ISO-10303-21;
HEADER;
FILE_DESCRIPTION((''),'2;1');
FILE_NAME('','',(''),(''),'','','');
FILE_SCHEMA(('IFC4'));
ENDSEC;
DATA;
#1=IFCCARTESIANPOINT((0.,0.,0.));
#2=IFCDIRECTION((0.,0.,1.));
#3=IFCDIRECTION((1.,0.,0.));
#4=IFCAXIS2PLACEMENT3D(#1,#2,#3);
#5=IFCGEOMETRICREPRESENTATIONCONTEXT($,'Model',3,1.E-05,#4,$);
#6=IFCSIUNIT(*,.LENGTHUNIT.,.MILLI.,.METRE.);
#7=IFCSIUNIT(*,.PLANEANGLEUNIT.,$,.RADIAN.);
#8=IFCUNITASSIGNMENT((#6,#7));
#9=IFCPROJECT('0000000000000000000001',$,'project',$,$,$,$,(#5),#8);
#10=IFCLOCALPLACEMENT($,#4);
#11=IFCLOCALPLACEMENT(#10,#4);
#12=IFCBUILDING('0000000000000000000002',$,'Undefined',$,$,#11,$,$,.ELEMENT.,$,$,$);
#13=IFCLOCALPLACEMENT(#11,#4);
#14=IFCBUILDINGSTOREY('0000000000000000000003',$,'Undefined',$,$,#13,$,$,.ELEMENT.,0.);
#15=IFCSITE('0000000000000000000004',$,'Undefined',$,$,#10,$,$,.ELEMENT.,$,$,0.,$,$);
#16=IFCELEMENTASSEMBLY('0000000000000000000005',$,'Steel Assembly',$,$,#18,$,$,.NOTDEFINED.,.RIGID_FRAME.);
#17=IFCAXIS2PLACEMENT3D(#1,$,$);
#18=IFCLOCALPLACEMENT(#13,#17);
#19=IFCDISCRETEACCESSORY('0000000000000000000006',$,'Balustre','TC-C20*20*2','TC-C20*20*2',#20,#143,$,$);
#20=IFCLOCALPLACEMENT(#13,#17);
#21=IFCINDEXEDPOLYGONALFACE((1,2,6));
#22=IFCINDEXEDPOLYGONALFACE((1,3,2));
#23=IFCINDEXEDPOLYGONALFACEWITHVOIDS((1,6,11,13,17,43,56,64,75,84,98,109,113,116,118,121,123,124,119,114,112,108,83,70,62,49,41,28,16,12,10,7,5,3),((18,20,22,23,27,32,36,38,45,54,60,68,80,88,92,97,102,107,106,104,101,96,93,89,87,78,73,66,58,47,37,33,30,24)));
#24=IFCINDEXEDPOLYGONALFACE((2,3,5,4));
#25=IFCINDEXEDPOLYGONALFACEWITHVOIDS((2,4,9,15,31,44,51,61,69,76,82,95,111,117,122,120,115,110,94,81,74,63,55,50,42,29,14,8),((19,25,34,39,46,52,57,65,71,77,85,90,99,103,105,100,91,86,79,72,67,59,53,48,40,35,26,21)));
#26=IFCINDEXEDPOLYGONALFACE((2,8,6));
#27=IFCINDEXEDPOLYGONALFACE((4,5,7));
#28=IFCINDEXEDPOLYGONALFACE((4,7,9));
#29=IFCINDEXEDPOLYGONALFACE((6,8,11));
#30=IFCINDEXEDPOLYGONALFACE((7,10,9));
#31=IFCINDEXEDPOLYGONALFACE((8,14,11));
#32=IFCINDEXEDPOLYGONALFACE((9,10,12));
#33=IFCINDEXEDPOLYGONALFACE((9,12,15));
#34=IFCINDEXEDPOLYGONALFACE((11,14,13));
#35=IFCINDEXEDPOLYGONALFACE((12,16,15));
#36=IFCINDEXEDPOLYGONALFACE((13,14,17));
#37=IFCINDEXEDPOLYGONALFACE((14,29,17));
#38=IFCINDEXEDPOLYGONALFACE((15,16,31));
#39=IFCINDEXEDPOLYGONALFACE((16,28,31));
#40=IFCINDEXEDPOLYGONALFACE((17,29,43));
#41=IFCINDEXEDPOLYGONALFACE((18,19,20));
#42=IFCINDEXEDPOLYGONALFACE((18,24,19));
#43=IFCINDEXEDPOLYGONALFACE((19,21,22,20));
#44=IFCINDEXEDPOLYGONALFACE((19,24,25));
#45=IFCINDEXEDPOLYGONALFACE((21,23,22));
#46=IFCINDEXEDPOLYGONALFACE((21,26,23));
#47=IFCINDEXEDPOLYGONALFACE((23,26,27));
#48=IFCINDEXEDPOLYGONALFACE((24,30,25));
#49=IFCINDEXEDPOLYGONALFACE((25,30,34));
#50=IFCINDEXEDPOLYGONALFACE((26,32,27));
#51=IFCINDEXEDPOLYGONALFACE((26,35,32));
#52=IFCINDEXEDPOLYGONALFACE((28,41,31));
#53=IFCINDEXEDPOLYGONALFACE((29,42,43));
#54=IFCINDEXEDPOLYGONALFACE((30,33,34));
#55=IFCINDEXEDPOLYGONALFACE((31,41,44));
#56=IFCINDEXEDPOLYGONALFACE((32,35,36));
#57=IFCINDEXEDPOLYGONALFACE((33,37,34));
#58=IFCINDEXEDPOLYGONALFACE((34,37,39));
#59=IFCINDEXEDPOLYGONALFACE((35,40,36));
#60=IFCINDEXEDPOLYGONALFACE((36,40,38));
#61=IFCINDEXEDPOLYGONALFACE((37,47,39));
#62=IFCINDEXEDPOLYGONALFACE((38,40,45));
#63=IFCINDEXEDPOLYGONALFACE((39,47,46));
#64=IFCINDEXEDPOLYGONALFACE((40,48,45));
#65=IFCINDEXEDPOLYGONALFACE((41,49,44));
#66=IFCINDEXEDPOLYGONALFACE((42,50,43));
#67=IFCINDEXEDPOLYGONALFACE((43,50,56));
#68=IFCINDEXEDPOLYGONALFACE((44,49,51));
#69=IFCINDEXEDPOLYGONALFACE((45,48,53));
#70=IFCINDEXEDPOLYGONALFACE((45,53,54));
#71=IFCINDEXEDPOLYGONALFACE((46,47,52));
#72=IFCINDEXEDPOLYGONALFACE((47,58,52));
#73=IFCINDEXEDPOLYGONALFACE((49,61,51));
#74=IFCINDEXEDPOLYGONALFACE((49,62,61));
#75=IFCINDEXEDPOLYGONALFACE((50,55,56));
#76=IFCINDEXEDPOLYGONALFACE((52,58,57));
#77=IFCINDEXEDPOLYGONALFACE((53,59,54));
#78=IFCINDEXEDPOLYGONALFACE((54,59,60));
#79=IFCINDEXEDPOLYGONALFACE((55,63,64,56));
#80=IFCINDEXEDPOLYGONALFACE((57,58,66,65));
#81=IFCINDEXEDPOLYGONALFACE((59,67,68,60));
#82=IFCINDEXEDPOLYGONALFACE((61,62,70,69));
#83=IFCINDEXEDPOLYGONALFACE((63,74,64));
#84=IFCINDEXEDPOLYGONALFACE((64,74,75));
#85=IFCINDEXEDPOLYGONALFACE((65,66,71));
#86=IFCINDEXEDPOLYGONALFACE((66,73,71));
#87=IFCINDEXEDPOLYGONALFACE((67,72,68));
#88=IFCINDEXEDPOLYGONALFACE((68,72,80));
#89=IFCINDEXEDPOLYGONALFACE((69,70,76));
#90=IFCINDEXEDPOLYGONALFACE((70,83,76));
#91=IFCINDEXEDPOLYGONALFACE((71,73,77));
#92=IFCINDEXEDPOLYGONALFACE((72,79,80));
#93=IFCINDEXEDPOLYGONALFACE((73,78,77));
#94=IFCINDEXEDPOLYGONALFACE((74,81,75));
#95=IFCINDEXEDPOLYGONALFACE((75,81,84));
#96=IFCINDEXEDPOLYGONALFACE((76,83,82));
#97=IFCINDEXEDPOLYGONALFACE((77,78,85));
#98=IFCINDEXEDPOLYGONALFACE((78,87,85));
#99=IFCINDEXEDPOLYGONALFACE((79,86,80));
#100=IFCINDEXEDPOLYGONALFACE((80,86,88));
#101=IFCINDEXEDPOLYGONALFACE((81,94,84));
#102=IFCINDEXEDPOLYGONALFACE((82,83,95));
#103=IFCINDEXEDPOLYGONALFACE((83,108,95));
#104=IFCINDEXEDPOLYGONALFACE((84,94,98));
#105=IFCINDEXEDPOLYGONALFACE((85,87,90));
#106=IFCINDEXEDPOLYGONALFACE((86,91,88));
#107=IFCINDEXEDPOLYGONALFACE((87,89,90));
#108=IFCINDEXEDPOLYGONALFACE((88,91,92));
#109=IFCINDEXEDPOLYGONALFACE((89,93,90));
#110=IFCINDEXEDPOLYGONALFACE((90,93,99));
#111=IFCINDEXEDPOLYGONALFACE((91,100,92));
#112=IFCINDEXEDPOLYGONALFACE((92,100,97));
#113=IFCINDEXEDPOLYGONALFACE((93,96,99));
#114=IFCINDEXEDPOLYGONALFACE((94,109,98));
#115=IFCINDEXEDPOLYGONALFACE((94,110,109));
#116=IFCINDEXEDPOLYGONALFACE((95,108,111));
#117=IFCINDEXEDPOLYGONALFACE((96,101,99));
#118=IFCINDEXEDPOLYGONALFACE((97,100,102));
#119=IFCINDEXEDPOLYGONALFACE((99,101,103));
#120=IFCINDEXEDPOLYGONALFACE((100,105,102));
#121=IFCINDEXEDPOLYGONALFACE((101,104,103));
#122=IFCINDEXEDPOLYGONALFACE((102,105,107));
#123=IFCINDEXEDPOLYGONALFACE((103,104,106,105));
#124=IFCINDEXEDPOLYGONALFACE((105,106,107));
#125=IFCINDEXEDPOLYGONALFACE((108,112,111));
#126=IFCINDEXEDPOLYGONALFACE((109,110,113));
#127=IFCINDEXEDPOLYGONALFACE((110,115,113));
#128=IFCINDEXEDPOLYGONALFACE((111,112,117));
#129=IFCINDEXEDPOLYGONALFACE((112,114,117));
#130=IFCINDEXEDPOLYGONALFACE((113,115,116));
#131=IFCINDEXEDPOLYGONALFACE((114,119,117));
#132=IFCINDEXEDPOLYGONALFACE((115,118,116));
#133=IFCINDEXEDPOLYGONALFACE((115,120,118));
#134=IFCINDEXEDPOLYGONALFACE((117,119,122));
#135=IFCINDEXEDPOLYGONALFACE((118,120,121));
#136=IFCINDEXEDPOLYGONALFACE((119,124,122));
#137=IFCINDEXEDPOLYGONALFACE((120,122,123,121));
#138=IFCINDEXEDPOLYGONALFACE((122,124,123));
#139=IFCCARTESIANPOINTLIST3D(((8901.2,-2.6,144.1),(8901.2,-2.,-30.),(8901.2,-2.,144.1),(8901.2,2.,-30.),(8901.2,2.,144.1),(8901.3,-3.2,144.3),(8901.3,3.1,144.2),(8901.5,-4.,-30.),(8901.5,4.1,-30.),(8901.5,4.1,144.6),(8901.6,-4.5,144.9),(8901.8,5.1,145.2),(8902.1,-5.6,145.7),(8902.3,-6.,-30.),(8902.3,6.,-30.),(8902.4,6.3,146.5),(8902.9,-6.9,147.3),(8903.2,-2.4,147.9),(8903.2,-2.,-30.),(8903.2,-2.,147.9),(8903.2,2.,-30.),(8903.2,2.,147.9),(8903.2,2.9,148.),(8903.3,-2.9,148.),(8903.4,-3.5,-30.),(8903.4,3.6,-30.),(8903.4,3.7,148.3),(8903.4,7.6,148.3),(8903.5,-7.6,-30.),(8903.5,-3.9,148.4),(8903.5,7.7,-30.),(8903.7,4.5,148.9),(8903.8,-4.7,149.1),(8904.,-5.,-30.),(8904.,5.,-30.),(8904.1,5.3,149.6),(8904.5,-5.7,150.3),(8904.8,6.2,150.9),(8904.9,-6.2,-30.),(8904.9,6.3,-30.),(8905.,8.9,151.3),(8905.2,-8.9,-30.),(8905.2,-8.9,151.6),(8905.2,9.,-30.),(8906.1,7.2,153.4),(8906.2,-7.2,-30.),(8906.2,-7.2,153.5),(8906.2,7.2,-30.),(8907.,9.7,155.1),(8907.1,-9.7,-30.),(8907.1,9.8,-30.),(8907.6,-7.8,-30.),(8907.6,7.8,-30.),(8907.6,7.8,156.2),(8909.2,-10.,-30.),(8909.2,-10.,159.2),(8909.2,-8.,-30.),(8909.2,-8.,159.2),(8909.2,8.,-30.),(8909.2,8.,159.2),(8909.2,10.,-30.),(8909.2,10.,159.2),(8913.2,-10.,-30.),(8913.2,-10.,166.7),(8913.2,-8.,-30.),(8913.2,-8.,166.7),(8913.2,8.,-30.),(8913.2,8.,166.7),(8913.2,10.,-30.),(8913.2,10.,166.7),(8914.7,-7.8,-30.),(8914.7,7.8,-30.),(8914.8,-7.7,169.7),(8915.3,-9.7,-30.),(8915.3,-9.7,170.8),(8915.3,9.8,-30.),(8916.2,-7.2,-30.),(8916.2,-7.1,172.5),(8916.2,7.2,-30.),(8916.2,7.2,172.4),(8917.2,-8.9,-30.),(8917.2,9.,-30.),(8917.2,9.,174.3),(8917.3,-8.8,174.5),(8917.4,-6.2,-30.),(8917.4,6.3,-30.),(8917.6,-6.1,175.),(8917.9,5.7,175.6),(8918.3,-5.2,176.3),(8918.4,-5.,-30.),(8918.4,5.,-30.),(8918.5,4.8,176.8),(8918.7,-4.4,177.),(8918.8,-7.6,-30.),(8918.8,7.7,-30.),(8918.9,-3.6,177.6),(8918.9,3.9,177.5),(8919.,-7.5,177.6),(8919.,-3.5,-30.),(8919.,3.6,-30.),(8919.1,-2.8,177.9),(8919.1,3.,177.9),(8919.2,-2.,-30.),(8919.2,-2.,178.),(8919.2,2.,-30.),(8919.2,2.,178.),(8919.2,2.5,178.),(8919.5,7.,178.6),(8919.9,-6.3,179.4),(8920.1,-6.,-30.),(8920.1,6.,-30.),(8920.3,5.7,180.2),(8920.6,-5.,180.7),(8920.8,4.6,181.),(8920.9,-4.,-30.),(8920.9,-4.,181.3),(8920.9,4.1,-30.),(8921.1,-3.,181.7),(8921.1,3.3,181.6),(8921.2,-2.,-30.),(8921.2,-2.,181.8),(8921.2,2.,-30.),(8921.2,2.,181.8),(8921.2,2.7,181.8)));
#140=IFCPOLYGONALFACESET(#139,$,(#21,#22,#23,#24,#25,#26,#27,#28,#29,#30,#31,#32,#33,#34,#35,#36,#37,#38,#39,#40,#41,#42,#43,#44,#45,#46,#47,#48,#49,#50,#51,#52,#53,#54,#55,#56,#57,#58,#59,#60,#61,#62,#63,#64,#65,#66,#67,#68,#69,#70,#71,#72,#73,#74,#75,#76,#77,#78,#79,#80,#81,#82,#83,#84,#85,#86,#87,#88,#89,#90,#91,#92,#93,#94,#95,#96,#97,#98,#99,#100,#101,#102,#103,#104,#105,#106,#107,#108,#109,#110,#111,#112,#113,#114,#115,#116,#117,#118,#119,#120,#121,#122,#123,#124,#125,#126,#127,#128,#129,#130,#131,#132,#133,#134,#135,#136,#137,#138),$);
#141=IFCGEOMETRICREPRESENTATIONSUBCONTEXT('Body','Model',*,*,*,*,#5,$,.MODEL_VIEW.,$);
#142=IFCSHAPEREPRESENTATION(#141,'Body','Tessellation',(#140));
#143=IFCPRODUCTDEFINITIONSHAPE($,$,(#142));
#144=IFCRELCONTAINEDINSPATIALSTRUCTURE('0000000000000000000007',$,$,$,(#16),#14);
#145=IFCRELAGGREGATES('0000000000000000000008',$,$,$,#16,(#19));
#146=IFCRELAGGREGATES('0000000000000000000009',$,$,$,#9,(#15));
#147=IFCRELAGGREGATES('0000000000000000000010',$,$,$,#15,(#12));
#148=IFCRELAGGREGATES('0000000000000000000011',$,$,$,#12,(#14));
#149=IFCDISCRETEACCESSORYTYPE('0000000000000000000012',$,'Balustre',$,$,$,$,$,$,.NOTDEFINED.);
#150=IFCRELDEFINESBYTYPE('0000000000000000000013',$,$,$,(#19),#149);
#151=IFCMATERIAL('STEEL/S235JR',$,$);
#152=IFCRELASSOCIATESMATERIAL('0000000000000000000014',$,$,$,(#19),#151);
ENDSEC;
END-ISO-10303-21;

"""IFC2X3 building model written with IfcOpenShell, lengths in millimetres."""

from ifc_helpers import new_model, si_unit, frame, origin_with_axes, origin_2d_with_axis, place, context, subcontext, project, spatial, hollow_rectangle, extrude, clip, halfspace, material, type_object, element, aggregate, save


model = new_model("IFC2X3")

# Units and contexts
model_context = context("Model", 3, precision=1e-05, world=origin_with_axes())
body_context = subcontext(model_context, "Body", "Model", "MODEL_VIEW")
ifc_project = project(units=[si_unit("LENGTHUNIT", "METRE", prefix="MILLI"), si_unit("PLANEANGLEUNIT", "RADIAN")], contexts=[model_context])

# Site, building, storey
site_placement = place(None, origin_with_axes())
site = spatial("IfcSite", under=ifc_project, at=site_placement, Name="Undefined", CompositionType="ELEMENT", RefElevation=0.0)
building_placement = place(site_placement, origin_with_axes())
building = spatial("IfcBuilding", under=site, at=building_placement, Name="Undefined", CompositionType="ELEMENT")
storey_placement = place(building_placement, origin_with_axes())
storey = spatial("IfcBuildingStorey", under=building, at=storey_placement, Name="Undefined", CompositionType="ELEMENT", Elevation=0.0)

# Element assembly
assembly_1_placement = place(storey_placement, origin_with_axes())
assembly_1 = element("IfcElementAssembly", 1, at=assembly_1_placement, inside=storey, Name="Steel Assembly", AssemblyPlace="NOTDEFINED", PredefinedType="RIGID_FRAME")
ifc_material = material(Name="STEEL/S235JR")

# Shared definitions
discrete_accessory_type_1 = type_object("IfcDiscreteAccessoryType", Name="Balustre")

# Discrete accessory
discrete_accessory_1_placement = place(assembly_1_placement, frame((8911.2, 0.0, -30.0), z_axis=(0.0, 0.0, 1.0), x_axis=(1.0, 0.0, 0.0)))
discrete_accessory_1 = element("IfcDiscreteAccessory", 2, at=discrete_accessory_1_placement, type_object=discrete_accessory_type_1, material=ifc_material, Name="Balustre", Description="TC-C20*20*2", ObjectType="TC-C20*20*2", context=body_context, shape_type="Clipping", body=[
    clip(extrude(hollow_rectangle(XDim=20.0, YDim=20.0, WallThickness=2.0, InnerFilletRadius=6.0, OuterFilletRadius=8.0, at=origin_2d_with_axis()), frame((0.0, 0.0, 212.0), z_axis=(0.0, 0.0, -1.0), x_axis=(-1.0, 0.0, 0.0)), (0.0, 0.0, 1.0), 212.0), halfspace(frame((15.1, 0.0, 221.5), z_axis=(0.883506, 0.000005, -0.46842), x_axis=(-0.000005, 1.0, 0.0)), True)),
])

aggregate(assembly_1, [discrete_accessory_1])

save(model, "model.ifc")
